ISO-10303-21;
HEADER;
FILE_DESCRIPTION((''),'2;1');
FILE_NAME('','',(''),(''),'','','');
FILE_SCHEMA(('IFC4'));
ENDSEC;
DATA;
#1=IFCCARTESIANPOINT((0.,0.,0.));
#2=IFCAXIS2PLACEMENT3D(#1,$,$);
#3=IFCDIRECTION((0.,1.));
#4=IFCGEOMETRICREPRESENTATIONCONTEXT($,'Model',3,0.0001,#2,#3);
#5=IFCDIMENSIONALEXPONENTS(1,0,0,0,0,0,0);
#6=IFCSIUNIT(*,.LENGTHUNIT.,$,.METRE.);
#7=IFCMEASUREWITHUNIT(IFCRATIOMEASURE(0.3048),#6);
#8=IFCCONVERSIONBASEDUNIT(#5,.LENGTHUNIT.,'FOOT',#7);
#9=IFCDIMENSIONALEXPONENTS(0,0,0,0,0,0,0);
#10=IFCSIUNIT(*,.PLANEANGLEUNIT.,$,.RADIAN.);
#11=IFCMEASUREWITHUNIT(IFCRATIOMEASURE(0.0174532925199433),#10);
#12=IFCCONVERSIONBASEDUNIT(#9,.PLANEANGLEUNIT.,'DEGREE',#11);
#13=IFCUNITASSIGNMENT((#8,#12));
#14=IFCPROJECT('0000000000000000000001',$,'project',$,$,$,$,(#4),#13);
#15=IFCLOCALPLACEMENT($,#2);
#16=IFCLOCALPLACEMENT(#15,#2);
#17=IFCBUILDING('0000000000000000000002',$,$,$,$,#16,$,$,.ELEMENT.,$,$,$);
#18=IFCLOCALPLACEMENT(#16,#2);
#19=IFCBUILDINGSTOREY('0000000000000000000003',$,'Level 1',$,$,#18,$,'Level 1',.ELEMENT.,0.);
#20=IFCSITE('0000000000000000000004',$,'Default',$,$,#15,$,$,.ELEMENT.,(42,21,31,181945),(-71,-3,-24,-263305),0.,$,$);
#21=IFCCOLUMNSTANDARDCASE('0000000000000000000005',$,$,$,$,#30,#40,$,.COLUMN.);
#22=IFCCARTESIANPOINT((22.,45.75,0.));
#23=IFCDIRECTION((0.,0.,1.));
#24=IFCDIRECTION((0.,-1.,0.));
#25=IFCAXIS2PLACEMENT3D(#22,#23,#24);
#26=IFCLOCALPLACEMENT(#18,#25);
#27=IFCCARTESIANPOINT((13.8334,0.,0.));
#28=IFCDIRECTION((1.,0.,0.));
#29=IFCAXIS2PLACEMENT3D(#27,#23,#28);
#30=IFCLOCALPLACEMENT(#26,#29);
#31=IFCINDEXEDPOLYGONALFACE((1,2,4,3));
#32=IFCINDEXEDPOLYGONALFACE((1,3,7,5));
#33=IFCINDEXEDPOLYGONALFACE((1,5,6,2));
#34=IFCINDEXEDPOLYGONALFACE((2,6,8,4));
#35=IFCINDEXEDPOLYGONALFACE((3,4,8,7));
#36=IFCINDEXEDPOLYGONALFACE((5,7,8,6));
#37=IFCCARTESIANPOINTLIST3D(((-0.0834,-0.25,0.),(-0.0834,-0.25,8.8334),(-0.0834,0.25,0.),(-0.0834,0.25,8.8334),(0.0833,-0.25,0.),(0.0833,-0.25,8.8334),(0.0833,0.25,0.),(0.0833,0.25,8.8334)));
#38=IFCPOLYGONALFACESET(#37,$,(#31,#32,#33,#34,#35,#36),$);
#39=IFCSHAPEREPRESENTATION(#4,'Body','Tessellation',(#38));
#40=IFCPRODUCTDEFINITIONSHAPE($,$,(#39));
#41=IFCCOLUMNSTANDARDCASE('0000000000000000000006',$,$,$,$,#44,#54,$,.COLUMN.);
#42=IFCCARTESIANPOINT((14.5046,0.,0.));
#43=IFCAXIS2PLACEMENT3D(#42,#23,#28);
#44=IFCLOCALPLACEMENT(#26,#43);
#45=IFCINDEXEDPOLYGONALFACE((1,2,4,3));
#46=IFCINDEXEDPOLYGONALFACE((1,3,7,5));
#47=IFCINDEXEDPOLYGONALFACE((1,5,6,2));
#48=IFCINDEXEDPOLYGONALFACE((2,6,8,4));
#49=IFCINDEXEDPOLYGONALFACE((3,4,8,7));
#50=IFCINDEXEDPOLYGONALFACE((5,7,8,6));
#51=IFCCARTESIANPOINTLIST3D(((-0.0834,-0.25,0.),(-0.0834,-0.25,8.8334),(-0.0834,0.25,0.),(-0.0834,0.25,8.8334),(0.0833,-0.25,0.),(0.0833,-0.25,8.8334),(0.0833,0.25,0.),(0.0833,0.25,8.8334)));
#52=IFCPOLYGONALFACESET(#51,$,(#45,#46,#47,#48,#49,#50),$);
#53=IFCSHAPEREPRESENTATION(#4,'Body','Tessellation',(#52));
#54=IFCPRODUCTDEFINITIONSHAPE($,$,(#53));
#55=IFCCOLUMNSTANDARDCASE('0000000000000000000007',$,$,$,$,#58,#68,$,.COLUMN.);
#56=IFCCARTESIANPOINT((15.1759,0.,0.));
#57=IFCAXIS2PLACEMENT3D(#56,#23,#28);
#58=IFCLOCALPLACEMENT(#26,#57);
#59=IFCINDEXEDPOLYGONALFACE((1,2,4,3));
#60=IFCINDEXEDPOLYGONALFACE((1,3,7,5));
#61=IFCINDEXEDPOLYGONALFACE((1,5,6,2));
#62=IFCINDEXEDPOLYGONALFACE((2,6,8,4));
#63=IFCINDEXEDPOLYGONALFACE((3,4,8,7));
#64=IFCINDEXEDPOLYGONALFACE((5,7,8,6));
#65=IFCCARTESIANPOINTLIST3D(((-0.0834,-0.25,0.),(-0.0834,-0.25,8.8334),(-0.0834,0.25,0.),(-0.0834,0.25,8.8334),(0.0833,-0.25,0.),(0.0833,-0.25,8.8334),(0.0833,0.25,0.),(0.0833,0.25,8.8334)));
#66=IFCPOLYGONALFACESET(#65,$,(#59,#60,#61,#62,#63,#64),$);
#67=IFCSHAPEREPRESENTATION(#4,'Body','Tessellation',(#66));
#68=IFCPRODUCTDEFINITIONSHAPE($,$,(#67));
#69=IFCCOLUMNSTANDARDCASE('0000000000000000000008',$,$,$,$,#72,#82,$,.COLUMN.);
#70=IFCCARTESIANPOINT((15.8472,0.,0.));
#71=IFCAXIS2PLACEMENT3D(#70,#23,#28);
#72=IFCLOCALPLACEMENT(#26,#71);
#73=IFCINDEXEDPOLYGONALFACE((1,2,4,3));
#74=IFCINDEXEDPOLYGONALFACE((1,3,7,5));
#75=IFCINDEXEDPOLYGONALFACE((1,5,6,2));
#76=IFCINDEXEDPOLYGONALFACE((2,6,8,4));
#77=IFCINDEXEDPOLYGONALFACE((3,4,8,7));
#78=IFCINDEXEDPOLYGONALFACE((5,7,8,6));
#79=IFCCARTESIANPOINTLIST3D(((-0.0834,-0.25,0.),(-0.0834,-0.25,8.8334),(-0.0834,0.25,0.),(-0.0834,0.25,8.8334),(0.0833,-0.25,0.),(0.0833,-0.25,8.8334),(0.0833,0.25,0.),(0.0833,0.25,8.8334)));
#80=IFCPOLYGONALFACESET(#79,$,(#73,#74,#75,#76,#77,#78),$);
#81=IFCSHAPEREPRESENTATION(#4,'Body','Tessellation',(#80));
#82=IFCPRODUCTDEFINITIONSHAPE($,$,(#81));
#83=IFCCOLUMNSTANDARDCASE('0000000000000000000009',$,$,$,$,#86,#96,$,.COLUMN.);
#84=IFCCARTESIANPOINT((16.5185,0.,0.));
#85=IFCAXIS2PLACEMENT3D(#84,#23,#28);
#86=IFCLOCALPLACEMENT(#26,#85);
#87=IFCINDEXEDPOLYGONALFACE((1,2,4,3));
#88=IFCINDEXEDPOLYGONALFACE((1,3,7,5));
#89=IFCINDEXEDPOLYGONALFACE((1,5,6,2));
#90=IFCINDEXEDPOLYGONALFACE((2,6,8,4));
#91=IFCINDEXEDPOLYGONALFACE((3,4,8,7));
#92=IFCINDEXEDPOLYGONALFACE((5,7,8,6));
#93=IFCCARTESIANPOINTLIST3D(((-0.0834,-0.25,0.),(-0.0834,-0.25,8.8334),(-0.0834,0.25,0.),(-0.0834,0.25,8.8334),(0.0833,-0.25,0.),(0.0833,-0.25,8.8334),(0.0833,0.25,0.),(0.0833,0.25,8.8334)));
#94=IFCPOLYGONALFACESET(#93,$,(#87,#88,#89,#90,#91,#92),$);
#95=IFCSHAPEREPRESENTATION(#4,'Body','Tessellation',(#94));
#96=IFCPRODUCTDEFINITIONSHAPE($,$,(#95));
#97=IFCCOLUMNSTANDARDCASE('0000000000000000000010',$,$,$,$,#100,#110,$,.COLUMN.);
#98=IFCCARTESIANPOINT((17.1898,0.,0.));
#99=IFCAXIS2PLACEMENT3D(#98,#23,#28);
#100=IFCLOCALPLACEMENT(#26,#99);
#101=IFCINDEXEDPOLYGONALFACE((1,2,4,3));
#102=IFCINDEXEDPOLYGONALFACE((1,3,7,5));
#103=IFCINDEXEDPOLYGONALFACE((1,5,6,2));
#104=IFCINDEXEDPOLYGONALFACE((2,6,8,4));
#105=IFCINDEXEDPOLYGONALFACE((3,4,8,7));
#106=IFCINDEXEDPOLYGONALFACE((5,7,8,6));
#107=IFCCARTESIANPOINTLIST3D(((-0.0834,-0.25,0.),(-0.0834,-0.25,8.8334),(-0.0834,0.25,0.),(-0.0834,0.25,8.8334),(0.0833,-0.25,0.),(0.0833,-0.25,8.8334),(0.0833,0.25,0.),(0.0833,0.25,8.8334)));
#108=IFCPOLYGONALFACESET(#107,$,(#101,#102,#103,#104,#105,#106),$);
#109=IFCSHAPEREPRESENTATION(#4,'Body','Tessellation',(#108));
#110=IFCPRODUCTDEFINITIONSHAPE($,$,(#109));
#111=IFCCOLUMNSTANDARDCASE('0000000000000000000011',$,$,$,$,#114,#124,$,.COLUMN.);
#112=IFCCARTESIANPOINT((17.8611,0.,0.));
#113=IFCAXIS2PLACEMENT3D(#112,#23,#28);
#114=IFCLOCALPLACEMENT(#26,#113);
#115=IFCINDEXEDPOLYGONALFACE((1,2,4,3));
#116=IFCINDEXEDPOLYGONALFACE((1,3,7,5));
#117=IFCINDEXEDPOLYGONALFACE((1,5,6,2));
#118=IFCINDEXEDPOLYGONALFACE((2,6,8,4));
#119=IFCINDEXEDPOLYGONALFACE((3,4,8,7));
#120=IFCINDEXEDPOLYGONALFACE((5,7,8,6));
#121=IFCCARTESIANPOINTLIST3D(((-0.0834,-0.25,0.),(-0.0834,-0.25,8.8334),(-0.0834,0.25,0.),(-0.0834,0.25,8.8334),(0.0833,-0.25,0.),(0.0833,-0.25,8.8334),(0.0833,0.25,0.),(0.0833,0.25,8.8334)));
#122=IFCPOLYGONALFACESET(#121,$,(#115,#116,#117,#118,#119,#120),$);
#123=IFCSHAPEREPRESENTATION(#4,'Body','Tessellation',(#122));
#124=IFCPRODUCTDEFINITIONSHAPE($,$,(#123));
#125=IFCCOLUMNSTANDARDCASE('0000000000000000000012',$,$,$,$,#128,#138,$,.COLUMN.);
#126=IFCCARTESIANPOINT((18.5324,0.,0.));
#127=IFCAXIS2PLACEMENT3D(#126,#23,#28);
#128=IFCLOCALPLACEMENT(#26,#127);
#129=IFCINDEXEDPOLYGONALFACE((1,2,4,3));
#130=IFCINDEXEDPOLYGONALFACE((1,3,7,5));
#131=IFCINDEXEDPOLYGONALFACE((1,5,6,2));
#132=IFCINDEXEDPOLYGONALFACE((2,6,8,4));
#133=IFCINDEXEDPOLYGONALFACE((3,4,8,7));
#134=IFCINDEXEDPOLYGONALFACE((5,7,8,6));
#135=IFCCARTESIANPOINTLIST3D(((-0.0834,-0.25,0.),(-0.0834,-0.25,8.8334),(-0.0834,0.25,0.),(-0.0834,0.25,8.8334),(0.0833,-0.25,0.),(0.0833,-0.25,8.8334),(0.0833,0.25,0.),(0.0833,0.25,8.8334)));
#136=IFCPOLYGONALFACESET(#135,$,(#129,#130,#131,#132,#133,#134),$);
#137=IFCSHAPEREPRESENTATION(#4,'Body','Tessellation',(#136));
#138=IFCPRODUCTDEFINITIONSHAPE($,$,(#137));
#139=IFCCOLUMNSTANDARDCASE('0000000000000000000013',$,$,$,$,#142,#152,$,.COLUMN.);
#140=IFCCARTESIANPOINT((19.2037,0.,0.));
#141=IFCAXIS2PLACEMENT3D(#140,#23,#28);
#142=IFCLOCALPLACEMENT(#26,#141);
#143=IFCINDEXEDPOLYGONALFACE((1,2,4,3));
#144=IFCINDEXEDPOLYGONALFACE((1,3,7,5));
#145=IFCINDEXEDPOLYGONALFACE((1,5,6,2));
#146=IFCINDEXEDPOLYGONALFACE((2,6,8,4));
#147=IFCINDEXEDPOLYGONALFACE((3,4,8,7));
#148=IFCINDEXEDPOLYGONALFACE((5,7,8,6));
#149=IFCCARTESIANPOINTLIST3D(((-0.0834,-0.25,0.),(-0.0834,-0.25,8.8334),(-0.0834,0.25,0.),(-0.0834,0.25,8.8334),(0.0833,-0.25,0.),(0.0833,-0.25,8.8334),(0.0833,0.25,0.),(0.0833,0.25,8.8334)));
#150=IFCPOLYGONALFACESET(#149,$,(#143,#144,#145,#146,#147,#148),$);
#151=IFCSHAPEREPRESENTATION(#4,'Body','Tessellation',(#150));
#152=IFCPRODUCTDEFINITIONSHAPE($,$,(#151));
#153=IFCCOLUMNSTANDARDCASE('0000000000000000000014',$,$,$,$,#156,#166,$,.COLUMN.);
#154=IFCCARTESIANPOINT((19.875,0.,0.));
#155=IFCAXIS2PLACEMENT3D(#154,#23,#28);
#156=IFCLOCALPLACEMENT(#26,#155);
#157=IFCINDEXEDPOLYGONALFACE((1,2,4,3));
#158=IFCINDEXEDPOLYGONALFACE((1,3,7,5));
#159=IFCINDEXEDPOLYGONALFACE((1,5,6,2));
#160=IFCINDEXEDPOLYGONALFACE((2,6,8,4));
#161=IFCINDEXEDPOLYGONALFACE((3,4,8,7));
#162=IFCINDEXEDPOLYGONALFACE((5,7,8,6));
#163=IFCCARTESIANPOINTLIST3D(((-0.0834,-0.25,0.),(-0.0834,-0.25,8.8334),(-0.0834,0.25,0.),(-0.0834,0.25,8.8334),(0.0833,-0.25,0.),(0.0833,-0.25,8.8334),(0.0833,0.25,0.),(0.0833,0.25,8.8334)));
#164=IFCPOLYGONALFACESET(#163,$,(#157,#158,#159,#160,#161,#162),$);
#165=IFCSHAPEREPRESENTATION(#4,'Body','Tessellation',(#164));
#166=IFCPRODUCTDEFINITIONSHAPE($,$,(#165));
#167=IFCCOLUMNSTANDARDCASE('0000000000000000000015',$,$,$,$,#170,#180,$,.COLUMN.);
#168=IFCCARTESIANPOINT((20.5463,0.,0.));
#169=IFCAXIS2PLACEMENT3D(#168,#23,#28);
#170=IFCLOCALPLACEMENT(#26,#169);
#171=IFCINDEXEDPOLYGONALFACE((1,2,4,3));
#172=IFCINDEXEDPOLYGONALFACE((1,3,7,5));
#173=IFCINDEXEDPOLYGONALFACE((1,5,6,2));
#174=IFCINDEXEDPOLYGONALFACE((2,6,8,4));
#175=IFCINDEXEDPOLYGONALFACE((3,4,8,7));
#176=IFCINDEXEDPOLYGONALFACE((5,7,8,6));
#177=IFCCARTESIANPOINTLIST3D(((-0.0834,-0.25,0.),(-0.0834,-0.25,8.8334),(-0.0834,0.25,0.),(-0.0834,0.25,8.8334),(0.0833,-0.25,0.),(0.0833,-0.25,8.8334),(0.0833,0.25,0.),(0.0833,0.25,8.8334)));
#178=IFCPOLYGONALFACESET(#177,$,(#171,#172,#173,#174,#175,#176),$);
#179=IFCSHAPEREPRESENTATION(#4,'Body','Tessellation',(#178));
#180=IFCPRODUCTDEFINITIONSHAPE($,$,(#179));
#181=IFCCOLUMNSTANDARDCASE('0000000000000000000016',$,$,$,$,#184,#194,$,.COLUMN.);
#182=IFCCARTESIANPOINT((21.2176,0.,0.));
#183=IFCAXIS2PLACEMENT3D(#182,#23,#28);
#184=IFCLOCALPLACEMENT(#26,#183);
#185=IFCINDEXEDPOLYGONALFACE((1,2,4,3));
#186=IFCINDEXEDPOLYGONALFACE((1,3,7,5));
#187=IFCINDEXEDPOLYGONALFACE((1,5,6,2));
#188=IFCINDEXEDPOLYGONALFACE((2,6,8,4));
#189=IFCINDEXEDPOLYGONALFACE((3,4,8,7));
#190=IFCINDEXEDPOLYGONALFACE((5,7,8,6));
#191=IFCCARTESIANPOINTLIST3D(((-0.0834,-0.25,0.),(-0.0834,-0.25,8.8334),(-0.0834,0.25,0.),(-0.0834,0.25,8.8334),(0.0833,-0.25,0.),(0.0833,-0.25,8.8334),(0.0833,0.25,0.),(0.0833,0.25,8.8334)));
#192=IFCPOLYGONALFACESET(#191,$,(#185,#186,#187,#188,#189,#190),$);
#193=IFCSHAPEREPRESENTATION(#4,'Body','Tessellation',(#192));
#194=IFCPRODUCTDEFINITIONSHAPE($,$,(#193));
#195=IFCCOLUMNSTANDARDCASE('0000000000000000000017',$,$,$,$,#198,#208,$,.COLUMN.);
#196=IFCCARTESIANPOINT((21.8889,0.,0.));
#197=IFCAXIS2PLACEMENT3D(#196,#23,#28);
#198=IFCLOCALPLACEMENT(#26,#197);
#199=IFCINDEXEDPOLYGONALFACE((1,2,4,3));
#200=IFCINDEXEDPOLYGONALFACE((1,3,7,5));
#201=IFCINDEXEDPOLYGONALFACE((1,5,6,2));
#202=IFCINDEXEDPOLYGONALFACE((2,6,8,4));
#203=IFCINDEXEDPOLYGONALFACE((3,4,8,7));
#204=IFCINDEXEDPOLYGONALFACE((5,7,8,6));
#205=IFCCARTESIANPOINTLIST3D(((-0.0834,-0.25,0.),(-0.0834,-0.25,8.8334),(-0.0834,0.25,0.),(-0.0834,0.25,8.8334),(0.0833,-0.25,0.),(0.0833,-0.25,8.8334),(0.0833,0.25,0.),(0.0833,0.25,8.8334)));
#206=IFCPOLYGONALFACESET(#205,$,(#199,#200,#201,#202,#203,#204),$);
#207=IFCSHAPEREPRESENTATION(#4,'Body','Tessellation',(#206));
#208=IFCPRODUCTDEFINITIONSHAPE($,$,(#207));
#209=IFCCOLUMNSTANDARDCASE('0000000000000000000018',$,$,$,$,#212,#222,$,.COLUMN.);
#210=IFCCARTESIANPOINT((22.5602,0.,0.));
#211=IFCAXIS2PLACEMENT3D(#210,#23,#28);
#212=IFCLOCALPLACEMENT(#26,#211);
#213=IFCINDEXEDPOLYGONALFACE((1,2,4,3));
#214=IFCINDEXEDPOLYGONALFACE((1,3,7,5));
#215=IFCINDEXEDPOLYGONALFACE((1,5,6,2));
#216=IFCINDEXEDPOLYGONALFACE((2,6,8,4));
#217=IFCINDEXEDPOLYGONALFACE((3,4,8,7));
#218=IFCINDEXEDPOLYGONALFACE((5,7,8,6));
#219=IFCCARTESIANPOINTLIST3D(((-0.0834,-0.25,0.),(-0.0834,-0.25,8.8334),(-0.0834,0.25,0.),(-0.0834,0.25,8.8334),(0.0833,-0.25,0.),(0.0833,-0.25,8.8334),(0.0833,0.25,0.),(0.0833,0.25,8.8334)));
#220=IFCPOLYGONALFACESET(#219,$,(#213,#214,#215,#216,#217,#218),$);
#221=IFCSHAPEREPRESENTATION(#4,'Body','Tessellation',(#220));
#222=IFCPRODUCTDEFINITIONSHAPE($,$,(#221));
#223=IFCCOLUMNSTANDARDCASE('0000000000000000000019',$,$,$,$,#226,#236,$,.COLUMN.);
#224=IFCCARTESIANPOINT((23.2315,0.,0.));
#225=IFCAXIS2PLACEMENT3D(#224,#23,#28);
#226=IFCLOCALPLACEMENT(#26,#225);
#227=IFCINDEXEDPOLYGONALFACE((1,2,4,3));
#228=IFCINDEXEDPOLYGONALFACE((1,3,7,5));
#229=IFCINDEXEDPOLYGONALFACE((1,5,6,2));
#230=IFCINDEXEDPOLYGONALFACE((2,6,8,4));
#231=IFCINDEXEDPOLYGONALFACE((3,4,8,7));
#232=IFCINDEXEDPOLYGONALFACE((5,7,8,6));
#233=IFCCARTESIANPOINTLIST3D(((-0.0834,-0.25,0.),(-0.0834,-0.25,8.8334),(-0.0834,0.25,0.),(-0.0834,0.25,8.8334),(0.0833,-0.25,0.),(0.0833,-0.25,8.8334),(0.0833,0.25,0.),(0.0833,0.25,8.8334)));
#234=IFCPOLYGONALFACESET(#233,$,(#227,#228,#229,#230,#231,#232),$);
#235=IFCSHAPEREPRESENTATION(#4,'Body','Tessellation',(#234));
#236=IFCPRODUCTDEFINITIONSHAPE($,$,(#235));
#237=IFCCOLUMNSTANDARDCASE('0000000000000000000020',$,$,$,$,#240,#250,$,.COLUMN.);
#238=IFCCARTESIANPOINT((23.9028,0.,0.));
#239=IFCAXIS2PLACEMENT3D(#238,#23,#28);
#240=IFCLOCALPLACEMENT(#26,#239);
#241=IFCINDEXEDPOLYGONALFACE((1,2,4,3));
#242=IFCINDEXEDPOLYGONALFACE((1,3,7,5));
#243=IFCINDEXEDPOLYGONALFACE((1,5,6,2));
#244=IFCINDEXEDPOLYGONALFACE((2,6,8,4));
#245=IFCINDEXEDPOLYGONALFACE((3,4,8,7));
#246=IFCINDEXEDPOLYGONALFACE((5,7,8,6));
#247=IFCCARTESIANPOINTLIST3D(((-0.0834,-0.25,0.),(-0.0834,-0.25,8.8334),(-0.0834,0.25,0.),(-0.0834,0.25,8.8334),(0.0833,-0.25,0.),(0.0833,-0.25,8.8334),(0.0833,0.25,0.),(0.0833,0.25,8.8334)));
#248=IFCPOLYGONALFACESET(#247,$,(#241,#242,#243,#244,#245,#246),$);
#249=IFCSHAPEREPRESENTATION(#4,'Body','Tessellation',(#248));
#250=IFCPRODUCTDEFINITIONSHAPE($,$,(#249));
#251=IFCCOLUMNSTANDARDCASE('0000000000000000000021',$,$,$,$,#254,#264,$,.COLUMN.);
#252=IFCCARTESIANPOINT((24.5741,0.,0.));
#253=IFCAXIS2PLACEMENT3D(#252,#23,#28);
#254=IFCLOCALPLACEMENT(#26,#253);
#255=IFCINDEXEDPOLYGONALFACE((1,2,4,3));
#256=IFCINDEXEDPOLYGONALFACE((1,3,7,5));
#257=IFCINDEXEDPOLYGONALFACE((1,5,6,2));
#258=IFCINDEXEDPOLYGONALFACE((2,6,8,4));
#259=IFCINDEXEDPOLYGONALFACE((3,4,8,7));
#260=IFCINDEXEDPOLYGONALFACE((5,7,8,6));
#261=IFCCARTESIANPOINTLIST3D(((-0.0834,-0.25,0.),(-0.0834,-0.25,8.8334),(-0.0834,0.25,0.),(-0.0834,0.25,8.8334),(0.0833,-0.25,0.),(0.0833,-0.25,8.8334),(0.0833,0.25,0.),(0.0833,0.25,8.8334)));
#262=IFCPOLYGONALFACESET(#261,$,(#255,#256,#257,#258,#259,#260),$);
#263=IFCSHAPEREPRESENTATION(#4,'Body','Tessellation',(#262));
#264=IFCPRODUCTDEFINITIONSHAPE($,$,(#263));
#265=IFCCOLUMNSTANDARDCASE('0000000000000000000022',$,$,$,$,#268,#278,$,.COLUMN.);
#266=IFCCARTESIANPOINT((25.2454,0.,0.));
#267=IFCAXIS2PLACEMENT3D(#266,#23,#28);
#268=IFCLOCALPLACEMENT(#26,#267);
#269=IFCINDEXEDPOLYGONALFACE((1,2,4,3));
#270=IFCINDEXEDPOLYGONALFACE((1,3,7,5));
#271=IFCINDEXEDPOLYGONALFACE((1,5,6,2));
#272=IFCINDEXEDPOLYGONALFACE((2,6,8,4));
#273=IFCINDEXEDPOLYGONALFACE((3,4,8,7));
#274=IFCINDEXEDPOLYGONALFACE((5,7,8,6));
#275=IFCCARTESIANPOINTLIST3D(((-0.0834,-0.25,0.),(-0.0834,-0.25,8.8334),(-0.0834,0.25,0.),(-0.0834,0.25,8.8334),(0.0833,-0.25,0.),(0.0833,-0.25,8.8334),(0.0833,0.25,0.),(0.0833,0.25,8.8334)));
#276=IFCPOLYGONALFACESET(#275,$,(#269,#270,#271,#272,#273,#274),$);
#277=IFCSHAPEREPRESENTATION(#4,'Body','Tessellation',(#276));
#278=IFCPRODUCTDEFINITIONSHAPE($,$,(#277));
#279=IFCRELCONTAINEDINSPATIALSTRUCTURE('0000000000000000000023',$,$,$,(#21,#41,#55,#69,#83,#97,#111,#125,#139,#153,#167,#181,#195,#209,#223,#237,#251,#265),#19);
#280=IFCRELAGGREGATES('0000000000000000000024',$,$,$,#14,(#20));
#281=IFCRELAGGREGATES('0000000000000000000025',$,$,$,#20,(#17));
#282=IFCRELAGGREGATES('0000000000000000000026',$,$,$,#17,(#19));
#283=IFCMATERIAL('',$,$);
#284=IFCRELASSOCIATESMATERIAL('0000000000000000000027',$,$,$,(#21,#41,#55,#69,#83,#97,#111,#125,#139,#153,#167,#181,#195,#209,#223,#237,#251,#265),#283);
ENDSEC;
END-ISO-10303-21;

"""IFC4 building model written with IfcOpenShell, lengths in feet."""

from ifc_helpers import new_model, entity, si_unit, converted_unit, direction, frame, origin, place, context, project, spatial, rectangle, extrude, material, element, save


model = new_model("IFC4")

# Units and contexts
model_context = context("Model", 3, precision=0.0001, world=origin(), true_north=direction((0.0, 1.0)))
ifc_project = project(units=[converted_unit("LENGTHUNIT", "FOOT", entity("IfcRatioMeasure", 0.3048), si_unit("LENGTHUNIT", "METRE"), dimensions=[1, 0, 0, 0, 0, 0, 0]), converted_unit("PLANEANGLEUNIT", "DEGREE", entity("IfcRatioMeasure", 0.0174532925199433), si_unit("PLANEANGLEUNIT", "RADIAN"), dimensions=[0, 0, 0, 0, 0, 0, 0])], contexts=[model_context])

# Site, building, storey
site_placement = place(None, origin())
site = spatial("IfcSite", under=ifc_project, at=site_placement, Name="Default", CompositionType="ELEMENT", RefLatitude=(42, 21, 31, 181945), RefLongitude=(-71, -3, -24, -263305), RefElevation=0.0)
building_placement = place(site_placement, origin())
building = spatial("IfcBuilding", under=site, at=building_placement, CompositionType="ELEMENT")
storey_placement = place(building_placement, origin())
storey = spatial("IfcBuildingStorey", under=building, at=storey_placement, Name="Level 1", LongName="Level 1", CompositionType="ELEMENT", Elevation=0.0)

# Columns
ifc_material_1 = material(Name="")
placement_1 = place(storey_placement, frame((22.0, 45.75, 0.0), z_axis=(0.0, 0.0, 1.0), x_axis=(0.0, -1.0, 0.0)))
for number, where, z_axis, x_axis in (
    (1, (13.8334, 0.0, 0.0), (0.0, 0.0, 1.0), (1.0, 0.0, 0.0)),
    (2, (14.5046, 0.0, 0.0), (0.0, 0.0, 1.0), (1.0, 0.0, 0.0)),
    (3, (15.1759, 0.0, 0.0), (0.0, 0.0, 1.0), (1.0, 0.0, 0.0)),
    (4, (15.8472, 0.0, 0.0), (0.0, 0.0, 1.0), (1.0, 0.0, 0.0)),
    (5, (16.5185, 0.0, 0.0), (0.0, 0.0, 1.0), (1.0, 0.0, 0.0)),
    (6, (17.1898, 0.0, 0.0), (0.0, 0.0, 1.0), (1.0, 0.0, 0.0)),
    (7, (17.8611, 0.0, 0.0), (0.0, 0.0, 1.0), (1.0, 0.0, 0.0)),
    (8, (18.5324, 0.0, 0.0), (0.0, 0.0, 1.0), (1.0, 0.0, 0.0)),
    (9, (19.2037, 0.0, 0.0), (0.0, 0.0, 1.0), (1.0, 0.0, 0.0)),
    (10, (19.875, 0.0, 0.0), (0.0, 0.0, 1.0), (1.0, 0.0, 0.0)),
    (11, (20.5463, 0.0, 0.0), (0.0, 0.0, 1.0), (1.0, 0.0, 0.0)),
    (12, (21.2176, 0.0, 0.0), (0.0, 0.0, 1.0), (1.0, 0.0, 0.0)),
    (13, (21.8889, 0.0, 0.0), (0.0, 0.0, 1.0), (1.0, 0.0, 0.0)),
    (14, (22.5602, 0.0, 0.0), (0.0, 0.0, 1.0), (1.0, 0.0, 0.0)),
    (15, (23.2315, 0.0, 0.0), (0.0, 0.0, 1.0), (1.0, 0.0, 0.0)),
    (16, (23.9028, 0.0, 0.0), (0.0, 0.0, 1.0), (1.0, 0.0, 0.0)),
    (17, (24.5741, 0.0, 0.0), (0.0, 0.0, 1.0), (1.0, 0.0, 0.0)),
    (18, (25.2454, 0.0, 0.0), (0.0, 0.0, 1.0), (1.0, 0.0, 0.0)),
):
    element("IfcColumnStandardCase", number, at=place(placement_1, frame(where, z_axis=z_axis, x_axis=x_axis)), inside=storey, material=ifc_material_1, PredefinedType="COLUMN", context=model_context, shape_type="SweptSolid", body=[
        extrude(rectangle(XDim=0.1667, YDim=0.5), origin(), (0.0, 0.0, 1.0), 8.8334),
    ])

save(model, "model.ifc")
